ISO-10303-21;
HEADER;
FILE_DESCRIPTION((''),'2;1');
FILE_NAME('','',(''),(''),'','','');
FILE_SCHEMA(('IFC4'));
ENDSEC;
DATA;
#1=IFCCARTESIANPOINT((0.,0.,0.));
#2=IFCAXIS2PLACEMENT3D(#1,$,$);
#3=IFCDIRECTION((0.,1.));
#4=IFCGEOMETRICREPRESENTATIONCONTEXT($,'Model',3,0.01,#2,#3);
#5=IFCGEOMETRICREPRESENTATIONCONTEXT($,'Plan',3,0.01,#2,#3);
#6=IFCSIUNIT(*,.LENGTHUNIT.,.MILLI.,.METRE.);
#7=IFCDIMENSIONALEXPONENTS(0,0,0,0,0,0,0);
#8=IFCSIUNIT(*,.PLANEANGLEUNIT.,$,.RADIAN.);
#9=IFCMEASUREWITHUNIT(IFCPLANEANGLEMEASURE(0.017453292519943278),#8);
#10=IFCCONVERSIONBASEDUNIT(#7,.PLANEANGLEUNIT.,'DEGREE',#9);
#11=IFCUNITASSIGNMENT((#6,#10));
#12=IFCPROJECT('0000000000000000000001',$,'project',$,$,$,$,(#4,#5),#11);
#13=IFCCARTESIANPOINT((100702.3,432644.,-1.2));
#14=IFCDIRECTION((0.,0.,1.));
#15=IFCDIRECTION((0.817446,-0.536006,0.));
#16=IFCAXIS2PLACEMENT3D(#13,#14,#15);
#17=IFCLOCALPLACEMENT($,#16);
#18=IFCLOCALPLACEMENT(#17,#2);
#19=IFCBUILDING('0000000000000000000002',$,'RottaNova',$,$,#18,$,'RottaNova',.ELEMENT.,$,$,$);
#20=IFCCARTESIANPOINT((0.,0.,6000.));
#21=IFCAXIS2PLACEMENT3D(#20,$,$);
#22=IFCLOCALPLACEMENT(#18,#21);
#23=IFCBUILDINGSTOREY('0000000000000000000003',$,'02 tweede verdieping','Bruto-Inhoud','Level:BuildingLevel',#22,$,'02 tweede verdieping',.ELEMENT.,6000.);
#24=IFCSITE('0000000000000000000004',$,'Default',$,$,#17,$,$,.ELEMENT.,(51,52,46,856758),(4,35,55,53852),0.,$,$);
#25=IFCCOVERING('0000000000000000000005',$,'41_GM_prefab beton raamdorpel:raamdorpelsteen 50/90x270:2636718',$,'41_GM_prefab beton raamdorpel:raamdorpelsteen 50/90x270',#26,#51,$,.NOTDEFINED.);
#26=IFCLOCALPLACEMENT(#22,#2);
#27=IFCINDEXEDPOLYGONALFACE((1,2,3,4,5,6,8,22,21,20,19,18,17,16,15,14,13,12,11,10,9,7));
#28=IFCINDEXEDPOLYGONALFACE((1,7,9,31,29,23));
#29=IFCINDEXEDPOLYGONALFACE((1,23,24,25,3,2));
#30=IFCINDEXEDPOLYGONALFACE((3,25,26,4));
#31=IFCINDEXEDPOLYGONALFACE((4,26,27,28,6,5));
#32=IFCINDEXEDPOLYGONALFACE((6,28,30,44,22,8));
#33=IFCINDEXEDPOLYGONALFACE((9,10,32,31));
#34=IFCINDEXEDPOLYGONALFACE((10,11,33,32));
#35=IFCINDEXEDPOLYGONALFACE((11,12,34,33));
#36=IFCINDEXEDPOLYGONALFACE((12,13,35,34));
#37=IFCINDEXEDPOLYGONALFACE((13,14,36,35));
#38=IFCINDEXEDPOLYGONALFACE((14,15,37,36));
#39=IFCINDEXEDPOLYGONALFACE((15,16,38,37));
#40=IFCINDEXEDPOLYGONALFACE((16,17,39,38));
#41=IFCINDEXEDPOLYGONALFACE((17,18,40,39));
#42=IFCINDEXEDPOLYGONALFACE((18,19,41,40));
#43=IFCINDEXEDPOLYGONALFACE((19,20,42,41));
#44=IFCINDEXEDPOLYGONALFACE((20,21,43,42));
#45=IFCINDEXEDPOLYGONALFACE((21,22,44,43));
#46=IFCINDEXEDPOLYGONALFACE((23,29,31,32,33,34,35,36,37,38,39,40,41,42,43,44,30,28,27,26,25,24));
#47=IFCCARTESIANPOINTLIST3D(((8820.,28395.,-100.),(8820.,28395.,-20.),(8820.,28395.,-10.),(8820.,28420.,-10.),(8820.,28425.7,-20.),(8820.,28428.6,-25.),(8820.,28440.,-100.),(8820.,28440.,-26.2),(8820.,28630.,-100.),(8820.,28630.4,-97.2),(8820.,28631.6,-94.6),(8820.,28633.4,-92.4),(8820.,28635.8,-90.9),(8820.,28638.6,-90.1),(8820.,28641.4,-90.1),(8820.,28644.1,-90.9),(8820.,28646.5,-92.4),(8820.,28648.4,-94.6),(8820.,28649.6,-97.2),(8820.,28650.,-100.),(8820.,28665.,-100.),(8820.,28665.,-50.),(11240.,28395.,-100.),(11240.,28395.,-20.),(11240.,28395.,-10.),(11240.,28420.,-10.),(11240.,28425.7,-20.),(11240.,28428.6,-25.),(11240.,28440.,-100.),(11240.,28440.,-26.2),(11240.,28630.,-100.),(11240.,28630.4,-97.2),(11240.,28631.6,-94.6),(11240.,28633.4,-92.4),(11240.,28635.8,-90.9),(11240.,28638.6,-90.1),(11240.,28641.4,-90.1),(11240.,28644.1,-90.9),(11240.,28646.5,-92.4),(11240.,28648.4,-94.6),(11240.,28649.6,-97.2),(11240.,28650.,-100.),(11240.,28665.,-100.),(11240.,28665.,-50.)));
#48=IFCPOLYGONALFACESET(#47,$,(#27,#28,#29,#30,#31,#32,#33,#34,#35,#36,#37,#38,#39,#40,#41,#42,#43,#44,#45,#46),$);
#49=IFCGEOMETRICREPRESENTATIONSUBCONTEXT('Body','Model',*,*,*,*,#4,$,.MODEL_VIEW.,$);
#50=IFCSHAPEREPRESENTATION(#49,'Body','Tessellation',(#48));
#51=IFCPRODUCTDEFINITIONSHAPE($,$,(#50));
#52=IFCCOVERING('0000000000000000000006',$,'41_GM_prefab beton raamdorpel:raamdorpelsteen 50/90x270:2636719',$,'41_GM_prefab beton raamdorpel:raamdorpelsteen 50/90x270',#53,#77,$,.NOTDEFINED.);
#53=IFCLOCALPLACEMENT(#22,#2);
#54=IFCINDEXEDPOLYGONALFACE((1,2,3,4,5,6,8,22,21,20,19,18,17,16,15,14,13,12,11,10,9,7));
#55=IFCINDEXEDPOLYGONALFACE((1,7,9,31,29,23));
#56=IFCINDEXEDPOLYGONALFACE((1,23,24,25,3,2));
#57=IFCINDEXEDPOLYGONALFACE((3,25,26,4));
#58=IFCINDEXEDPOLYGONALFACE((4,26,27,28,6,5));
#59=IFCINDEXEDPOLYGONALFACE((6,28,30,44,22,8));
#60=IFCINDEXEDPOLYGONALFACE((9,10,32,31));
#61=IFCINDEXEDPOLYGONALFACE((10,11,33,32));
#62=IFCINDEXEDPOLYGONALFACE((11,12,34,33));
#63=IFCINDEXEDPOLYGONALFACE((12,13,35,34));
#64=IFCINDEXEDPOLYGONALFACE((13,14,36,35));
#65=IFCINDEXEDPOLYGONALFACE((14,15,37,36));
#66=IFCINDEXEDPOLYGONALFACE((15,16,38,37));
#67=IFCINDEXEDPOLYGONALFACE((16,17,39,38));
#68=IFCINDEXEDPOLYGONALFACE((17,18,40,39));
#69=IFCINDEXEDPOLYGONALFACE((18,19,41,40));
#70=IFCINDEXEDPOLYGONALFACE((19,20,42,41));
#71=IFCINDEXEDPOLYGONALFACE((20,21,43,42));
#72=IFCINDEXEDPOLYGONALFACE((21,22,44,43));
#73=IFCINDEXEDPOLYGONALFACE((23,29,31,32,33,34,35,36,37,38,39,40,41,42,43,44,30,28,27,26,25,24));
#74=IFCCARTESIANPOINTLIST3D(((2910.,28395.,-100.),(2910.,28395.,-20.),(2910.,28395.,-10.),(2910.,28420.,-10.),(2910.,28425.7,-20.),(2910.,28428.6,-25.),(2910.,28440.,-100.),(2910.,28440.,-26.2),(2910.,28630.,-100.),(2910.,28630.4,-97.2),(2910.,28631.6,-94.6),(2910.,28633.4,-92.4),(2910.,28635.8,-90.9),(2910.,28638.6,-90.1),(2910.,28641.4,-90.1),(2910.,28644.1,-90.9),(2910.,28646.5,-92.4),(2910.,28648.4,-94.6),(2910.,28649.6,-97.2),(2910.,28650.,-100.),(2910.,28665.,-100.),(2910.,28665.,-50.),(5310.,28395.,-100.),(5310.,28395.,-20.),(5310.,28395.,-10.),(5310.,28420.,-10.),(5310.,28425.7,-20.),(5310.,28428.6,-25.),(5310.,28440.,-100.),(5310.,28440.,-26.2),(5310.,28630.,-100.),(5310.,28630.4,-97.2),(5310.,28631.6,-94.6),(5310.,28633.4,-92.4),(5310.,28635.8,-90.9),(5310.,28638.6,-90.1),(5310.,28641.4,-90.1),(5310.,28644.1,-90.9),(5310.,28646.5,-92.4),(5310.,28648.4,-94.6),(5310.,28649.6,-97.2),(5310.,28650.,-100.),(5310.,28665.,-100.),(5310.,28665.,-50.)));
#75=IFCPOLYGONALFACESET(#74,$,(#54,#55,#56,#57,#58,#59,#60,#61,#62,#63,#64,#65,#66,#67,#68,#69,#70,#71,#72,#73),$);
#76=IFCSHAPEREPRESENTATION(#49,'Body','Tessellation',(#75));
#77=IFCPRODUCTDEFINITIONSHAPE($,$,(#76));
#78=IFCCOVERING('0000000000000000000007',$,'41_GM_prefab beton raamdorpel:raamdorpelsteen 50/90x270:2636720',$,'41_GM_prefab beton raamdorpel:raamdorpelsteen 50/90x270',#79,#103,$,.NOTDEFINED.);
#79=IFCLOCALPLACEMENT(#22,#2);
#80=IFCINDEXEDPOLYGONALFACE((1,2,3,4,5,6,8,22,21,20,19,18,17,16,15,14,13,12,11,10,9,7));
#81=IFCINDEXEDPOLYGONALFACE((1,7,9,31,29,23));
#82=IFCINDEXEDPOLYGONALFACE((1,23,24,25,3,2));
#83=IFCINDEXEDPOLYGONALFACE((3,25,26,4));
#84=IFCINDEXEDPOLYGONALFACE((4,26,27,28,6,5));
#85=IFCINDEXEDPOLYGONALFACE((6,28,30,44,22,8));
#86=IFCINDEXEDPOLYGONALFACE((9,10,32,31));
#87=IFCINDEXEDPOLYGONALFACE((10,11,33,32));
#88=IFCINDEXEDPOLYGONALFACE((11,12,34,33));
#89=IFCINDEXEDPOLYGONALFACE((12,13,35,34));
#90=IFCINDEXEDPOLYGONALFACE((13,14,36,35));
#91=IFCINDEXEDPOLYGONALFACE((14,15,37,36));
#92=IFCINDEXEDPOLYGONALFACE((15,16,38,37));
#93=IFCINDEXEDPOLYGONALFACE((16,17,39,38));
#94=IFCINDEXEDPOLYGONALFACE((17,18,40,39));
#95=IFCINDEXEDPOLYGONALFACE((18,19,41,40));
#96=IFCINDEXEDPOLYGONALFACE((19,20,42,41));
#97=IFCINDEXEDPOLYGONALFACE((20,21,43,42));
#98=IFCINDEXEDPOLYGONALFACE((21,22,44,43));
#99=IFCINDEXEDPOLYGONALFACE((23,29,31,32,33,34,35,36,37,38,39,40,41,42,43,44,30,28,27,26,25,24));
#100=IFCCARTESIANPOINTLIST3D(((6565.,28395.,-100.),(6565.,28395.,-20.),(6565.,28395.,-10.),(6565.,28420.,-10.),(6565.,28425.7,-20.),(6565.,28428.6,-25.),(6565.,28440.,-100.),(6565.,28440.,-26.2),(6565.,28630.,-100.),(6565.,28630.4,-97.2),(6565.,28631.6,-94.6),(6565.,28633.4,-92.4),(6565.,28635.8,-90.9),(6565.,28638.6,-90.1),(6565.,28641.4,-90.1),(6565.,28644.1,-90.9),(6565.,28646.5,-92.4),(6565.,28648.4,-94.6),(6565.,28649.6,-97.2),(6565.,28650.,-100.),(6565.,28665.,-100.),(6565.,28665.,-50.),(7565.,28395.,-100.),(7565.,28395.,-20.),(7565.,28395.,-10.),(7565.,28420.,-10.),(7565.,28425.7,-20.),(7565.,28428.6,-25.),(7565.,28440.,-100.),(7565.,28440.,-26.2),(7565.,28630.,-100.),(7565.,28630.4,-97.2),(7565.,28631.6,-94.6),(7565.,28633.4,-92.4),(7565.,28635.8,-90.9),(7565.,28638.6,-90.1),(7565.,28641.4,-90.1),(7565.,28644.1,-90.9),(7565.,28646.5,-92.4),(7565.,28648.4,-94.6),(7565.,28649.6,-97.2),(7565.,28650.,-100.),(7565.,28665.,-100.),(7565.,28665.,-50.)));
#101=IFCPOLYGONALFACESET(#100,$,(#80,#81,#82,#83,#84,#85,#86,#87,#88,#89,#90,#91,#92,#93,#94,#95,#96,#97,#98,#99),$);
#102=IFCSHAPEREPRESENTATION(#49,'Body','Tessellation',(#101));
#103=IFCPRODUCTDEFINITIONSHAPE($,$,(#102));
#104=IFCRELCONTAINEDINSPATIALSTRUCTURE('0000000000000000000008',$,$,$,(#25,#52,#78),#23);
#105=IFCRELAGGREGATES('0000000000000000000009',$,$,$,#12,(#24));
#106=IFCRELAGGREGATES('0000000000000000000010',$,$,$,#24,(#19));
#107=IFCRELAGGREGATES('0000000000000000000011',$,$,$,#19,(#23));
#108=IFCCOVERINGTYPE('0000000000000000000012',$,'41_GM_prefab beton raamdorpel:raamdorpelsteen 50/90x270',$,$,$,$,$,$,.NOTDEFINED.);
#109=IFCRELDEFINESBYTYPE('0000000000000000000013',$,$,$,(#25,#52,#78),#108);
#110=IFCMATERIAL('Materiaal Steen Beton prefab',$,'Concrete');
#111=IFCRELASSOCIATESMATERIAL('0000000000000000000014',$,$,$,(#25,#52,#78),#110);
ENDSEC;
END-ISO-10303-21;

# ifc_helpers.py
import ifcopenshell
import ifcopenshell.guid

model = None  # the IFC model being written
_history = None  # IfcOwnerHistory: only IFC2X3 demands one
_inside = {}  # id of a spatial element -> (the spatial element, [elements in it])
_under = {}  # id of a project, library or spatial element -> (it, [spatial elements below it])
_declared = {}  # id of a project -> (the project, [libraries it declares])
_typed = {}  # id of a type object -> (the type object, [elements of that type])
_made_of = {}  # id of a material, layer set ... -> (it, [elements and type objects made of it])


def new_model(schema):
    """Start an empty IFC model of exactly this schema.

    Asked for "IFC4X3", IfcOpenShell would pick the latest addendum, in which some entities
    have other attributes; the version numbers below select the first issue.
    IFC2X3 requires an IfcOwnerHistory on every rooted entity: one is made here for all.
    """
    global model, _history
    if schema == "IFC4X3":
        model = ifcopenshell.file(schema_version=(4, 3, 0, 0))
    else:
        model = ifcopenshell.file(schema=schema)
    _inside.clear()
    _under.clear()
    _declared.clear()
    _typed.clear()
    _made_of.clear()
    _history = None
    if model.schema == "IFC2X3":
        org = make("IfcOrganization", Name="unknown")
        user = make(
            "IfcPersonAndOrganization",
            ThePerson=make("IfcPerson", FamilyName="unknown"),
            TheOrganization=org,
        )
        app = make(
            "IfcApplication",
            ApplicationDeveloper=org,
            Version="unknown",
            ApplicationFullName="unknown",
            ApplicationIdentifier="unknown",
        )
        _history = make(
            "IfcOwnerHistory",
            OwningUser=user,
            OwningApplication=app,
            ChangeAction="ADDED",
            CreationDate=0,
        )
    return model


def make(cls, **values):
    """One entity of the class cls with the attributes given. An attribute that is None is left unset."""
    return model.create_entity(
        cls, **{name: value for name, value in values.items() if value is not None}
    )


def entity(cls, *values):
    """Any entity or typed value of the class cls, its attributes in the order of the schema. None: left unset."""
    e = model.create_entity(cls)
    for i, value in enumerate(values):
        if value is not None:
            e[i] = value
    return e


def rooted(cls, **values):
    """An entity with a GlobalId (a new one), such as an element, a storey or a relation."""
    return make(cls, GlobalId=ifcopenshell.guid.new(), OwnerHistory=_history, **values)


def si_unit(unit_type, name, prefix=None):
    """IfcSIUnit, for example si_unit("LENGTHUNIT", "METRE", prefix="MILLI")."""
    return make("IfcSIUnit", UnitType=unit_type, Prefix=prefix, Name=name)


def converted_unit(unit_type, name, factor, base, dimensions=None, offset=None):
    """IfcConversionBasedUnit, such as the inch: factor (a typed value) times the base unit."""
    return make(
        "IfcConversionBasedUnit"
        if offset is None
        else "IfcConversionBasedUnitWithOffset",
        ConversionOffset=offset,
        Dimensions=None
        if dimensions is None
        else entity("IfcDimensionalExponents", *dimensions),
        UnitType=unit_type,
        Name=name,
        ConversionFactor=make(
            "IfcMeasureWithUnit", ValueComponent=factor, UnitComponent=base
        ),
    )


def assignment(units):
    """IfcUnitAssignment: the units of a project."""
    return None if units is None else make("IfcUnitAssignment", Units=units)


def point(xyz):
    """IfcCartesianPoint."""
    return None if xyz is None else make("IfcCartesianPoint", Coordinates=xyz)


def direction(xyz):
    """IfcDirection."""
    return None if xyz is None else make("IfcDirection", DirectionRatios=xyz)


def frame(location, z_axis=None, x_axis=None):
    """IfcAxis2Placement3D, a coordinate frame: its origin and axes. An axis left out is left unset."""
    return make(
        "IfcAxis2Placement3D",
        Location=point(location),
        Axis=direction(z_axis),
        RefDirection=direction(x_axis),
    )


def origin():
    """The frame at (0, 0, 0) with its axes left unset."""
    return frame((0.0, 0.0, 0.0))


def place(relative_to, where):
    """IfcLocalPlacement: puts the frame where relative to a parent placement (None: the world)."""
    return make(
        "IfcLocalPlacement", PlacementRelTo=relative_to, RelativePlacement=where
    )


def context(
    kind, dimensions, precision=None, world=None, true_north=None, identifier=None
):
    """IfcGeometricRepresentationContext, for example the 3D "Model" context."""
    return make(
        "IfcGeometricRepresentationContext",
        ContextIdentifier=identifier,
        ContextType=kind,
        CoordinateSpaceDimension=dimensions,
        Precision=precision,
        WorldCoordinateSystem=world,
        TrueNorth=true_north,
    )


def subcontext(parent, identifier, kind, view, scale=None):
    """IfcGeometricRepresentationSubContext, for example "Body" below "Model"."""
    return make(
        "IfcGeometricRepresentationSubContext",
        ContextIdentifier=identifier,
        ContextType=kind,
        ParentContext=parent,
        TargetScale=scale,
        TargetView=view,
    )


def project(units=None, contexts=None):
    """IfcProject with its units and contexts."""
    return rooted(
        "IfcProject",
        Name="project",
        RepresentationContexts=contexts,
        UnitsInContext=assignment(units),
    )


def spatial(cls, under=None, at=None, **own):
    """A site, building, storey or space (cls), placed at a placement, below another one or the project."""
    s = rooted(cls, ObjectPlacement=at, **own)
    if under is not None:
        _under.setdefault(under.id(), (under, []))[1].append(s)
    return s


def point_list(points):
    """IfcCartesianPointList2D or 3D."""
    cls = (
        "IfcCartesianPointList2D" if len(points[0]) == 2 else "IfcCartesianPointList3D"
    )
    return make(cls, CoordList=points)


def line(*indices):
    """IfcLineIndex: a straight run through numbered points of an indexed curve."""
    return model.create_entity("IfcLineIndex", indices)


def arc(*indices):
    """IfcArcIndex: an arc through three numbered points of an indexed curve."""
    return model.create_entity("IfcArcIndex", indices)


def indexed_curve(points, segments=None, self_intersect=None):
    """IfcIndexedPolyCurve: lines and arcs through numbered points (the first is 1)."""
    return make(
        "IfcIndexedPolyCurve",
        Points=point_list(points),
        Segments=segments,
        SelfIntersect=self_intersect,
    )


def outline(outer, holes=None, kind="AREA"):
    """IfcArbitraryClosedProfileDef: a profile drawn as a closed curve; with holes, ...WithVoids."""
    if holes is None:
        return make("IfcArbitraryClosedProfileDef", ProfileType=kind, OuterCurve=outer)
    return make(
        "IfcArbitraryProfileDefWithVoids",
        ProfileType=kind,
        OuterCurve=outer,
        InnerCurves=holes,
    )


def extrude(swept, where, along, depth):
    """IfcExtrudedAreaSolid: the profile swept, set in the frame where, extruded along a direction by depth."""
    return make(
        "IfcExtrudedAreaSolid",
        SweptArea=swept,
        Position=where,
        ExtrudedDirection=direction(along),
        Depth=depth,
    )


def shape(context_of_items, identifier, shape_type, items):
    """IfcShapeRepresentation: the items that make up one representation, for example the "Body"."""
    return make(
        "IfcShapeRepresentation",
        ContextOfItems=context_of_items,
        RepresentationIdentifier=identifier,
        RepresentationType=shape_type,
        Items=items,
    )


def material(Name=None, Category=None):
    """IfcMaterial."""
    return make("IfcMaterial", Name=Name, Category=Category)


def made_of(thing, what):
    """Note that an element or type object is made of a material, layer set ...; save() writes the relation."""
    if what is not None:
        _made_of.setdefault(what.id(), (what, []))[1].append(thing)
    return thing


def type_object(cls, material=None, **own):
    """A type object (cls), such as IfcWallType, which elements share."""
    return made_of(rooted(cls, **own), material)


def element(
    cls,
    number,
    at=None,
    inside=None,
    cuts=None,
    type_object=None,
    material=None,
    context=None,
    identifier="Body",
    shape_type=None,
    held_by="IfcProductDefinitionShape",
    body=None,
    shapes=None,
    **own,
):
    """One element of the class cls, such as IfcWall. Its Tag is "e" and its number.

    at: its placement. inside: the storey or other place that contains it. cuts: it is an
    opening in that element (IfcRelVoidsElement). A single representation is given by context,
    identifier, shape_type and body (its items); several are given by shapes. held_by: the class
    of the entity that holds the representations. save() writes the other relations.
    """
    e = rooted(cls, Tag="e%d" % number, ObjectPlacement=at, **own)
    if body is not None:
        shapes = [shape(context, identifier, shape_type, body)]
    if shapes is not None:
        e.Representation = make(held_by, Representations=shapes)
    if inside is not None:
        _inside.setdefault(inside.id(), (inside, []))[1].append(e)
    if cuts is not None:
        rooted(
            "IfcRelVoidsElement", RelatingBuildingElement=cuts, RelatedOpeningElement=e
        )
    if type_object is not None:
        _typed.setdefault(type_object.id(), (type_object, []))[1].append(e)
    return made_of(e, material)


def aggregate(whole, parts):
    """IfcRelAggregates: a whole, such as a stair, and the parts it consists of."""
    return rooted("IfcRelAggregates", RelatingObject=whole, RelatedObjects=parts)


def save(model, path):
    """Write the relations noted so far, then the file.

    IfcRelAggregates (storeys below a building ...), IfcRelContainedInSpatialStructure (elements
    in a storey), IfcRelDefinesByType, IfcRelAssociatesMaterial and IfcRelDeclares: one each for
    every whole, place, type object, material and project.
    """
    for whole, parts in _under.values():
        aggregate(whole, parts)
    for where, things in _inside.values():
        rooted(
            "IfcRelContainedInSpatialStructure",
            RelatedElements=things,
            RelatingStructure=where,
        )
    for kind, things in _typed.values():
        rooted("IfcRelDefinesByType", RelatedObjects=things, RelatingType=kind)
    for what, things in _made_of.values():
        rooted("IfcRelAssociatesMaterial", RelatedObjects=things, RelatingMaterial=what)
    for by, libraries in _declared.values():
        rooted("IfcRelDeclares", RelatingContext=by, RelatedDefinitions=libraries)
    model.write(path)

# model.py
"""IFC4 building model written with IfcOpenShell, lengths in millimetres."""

from ifc_helpers import new_model, entity, si_unit, converted_unit, direction, frame, origin, place, context, subcontext, project, spatial, line, arc, indexed_curve, outline, extrude, material, type_object, element, save


model = new_model("IFC4")

# Units and contexts
model_context = context("Model", 3, precision=0.01, world=origin(), true_north=direction((0.0, 1.0)))
plan_context = context("Plan", 3, precision=0.01, world=origin(), true_north=direction((0.0, 1.0)))
body_context = subcontext(model_context, "Body", "Model", "MODEL_VIEW")
ifc_project = project(units=[si_unit("LENGTHUNIT", "METRE", prefix="MILLI"), converted_unit("PLANEANGLEUNIT", "DEGREE", entity("IfcPlaneAngleMeasure", 0.017453292519943278), si_unit("PLANEANGLEUNIT", "RADIAN"), dimensions=[0, 0, 0, 0, 0, 0, 0])], contexts=[model_context, plan_context])

# Site, building, storey
site_placement = place(None, frame((100702.3, 432644.0, -1.2), z_axis=(0.0, 0.0, 1.0), x_axis=(0.817446, -0.536006, 0.0)))
site = spatial("IfcSite", under=ifc_project, at=site_placement, Name="Default", CompositionType="ELEMENT", RefLatitude=(51, 52, 46, 856758), RefLongitude=(4, 35, 55, 53852), RefElevation=0.0)
building_placement = place(site_placement, origin())
building = spatial("IfcBuilding", under=site, at=building_placement, Name="RottaNova", LongName="RottaNova", CompositionType="ELEMENT")
storey_placement = place(building_placement, frame((0.0, 0.0, 6000.0)))
storey = spatial("IfcBuildingStorey", under=building, at=storey_placement, Name="02 tweede verdieping", Description="Bruto-Inhoud", ObjectType="Level:BuildingLevel", LongName="02 tweede verdieping", CompositionType="ELEMENT", Elevation=6000.0)

# Coverings
ifc_material_1 = material(Name="Materiaal Steen Beton prefab", Category="Concrete")
covering_type_1 = type_object("IfcCoveringType", Name="41_GM_prefab beton raamdorpel:raamdorpelsteen 50/90x270", PredefinedType="NOTDEFINED")
covering_1_placement = place(storey_placement, origin())
element("IfcCovering", 1, at=covering_1_placement, inside=storey, type_object=covering_type_1, material=ifc_material_1, Name="41_GM_prefab beton raamdorpel:raamdorpelsteen 50/90x270:2636718", ObjectType="41_GM_prefab beton raamdorpel:raamdorpelsteen 50/90x270", PredefinedType="NOTDEFINED", context=body_context, shape_type="SweptSolid", body=[
    extrude(outline(indexed_curve([(75.8, -45.1), (100.8, -45.1), (100.8, -35.1), (100.8, 44.9), (55.8, 44.9), (-134.2, 44.9), (-144.2, 34.9), (-154.2, 44.9), (-169.2, 44.9), (-169.2, -5.1), (55.8, -28.9), (67.1, -30.1), (70.0, -35.1)], segments=[line(1, 2, 3, 4, 5, 6), arc(6, 7, 8), line(8, 9, 10, 11, 12, 13, 1)], self_intersect=False)), frame((8820.0, 28495.8, -55.1), z_axis=(1.0, 0.0, 0.0), x_axis=(0.0, -1.0, 0.0)), (0.0, 0.0, 1.0), 2420.0),
])
covering_2_placement = place(storey_placement, origin())
element("IfcCovering", 2, at=covering_2_placement, inside=storey, type_object=covering_type_1, material=ifc_material_1, Name="41_GM_prefab beton raamdorpel:raamdorpelsteen 50/90x270:2636719", ObjectType="41_GM_prefab beton raamdorpel:raamdorpelsteen 50/90x270", PredefinedType="NOTDEFINED", context=body_context, shape_type="SweptSolid", body=[
    extrude(outline(indexed_curve([(75.8, -45.1), (100.8, -45.1), (100.8, -35.1), (100.8, 44.9), (55.8, 44.9), (-134.2, 44.9), (-144.2, 34.9), (-154.2, 44.9), (-169.2, 44.9), (-169.2, -5.1), (55.8, -28.9), (67.1, -30.1), (70.0, -35.1)], segments=[line(1, 2, 3, 4, 5, 6), arc(6, 7, 8), line(8, 9, 10, 11, 12, 13, 1)], self_intersect=False)), frame((2910.0, 28495.8, -55.1), z_axis=(1.0, 0.0, 0.0), x_axis=(0.0, -1.0, 0.0)), (0.0, 0.0, 1.0), 2400.0),
])
covering_3_placement = place(storey_placement, origin())
element("IfcCovering", 3, at=covering_3_placement, inside=storey, type_object=covering_type_1, material=ifc_material_1, Name="41_GM_prefab beton raamdorpel:raamdorpelsteen 50/90x270:2636720", ObjectType="41_GM_prefab beton raamdorpel:raamdorpelsteen 50/90x270", PredefinedType="NOTDEFINED", context=body_context, shape_type="SweptSolid", body=[
    extrude(outline(indexed_curve([(75.8, -45.1), (100.8, -45.1), (100.8, -35.1), (100.8, 44.9), (55.8, 44.9), (-134.2, 44.9), (-144.2, 34.9), (-154.2, 44.9), (-169.2, 44.9), (-169.2, -5.1), (55.8, -28.9), (67.1, -30.1), (70.0, -35.1)], segments=[line(1, 2, 3, 4, 5, 6), arc(6, 7, 8), line(8, 9, 10, 11, 12, 13, 1)], self_intersect=False)), frame((6565.0, 28495.8, -55.1), z_axis=(1.0, 0.0, 0.0), x_axis=(0.0, -1.0, 0.0)), (0.0, 0.0, 1.0), 1000.0),
])

save(model, "model.ifc")
